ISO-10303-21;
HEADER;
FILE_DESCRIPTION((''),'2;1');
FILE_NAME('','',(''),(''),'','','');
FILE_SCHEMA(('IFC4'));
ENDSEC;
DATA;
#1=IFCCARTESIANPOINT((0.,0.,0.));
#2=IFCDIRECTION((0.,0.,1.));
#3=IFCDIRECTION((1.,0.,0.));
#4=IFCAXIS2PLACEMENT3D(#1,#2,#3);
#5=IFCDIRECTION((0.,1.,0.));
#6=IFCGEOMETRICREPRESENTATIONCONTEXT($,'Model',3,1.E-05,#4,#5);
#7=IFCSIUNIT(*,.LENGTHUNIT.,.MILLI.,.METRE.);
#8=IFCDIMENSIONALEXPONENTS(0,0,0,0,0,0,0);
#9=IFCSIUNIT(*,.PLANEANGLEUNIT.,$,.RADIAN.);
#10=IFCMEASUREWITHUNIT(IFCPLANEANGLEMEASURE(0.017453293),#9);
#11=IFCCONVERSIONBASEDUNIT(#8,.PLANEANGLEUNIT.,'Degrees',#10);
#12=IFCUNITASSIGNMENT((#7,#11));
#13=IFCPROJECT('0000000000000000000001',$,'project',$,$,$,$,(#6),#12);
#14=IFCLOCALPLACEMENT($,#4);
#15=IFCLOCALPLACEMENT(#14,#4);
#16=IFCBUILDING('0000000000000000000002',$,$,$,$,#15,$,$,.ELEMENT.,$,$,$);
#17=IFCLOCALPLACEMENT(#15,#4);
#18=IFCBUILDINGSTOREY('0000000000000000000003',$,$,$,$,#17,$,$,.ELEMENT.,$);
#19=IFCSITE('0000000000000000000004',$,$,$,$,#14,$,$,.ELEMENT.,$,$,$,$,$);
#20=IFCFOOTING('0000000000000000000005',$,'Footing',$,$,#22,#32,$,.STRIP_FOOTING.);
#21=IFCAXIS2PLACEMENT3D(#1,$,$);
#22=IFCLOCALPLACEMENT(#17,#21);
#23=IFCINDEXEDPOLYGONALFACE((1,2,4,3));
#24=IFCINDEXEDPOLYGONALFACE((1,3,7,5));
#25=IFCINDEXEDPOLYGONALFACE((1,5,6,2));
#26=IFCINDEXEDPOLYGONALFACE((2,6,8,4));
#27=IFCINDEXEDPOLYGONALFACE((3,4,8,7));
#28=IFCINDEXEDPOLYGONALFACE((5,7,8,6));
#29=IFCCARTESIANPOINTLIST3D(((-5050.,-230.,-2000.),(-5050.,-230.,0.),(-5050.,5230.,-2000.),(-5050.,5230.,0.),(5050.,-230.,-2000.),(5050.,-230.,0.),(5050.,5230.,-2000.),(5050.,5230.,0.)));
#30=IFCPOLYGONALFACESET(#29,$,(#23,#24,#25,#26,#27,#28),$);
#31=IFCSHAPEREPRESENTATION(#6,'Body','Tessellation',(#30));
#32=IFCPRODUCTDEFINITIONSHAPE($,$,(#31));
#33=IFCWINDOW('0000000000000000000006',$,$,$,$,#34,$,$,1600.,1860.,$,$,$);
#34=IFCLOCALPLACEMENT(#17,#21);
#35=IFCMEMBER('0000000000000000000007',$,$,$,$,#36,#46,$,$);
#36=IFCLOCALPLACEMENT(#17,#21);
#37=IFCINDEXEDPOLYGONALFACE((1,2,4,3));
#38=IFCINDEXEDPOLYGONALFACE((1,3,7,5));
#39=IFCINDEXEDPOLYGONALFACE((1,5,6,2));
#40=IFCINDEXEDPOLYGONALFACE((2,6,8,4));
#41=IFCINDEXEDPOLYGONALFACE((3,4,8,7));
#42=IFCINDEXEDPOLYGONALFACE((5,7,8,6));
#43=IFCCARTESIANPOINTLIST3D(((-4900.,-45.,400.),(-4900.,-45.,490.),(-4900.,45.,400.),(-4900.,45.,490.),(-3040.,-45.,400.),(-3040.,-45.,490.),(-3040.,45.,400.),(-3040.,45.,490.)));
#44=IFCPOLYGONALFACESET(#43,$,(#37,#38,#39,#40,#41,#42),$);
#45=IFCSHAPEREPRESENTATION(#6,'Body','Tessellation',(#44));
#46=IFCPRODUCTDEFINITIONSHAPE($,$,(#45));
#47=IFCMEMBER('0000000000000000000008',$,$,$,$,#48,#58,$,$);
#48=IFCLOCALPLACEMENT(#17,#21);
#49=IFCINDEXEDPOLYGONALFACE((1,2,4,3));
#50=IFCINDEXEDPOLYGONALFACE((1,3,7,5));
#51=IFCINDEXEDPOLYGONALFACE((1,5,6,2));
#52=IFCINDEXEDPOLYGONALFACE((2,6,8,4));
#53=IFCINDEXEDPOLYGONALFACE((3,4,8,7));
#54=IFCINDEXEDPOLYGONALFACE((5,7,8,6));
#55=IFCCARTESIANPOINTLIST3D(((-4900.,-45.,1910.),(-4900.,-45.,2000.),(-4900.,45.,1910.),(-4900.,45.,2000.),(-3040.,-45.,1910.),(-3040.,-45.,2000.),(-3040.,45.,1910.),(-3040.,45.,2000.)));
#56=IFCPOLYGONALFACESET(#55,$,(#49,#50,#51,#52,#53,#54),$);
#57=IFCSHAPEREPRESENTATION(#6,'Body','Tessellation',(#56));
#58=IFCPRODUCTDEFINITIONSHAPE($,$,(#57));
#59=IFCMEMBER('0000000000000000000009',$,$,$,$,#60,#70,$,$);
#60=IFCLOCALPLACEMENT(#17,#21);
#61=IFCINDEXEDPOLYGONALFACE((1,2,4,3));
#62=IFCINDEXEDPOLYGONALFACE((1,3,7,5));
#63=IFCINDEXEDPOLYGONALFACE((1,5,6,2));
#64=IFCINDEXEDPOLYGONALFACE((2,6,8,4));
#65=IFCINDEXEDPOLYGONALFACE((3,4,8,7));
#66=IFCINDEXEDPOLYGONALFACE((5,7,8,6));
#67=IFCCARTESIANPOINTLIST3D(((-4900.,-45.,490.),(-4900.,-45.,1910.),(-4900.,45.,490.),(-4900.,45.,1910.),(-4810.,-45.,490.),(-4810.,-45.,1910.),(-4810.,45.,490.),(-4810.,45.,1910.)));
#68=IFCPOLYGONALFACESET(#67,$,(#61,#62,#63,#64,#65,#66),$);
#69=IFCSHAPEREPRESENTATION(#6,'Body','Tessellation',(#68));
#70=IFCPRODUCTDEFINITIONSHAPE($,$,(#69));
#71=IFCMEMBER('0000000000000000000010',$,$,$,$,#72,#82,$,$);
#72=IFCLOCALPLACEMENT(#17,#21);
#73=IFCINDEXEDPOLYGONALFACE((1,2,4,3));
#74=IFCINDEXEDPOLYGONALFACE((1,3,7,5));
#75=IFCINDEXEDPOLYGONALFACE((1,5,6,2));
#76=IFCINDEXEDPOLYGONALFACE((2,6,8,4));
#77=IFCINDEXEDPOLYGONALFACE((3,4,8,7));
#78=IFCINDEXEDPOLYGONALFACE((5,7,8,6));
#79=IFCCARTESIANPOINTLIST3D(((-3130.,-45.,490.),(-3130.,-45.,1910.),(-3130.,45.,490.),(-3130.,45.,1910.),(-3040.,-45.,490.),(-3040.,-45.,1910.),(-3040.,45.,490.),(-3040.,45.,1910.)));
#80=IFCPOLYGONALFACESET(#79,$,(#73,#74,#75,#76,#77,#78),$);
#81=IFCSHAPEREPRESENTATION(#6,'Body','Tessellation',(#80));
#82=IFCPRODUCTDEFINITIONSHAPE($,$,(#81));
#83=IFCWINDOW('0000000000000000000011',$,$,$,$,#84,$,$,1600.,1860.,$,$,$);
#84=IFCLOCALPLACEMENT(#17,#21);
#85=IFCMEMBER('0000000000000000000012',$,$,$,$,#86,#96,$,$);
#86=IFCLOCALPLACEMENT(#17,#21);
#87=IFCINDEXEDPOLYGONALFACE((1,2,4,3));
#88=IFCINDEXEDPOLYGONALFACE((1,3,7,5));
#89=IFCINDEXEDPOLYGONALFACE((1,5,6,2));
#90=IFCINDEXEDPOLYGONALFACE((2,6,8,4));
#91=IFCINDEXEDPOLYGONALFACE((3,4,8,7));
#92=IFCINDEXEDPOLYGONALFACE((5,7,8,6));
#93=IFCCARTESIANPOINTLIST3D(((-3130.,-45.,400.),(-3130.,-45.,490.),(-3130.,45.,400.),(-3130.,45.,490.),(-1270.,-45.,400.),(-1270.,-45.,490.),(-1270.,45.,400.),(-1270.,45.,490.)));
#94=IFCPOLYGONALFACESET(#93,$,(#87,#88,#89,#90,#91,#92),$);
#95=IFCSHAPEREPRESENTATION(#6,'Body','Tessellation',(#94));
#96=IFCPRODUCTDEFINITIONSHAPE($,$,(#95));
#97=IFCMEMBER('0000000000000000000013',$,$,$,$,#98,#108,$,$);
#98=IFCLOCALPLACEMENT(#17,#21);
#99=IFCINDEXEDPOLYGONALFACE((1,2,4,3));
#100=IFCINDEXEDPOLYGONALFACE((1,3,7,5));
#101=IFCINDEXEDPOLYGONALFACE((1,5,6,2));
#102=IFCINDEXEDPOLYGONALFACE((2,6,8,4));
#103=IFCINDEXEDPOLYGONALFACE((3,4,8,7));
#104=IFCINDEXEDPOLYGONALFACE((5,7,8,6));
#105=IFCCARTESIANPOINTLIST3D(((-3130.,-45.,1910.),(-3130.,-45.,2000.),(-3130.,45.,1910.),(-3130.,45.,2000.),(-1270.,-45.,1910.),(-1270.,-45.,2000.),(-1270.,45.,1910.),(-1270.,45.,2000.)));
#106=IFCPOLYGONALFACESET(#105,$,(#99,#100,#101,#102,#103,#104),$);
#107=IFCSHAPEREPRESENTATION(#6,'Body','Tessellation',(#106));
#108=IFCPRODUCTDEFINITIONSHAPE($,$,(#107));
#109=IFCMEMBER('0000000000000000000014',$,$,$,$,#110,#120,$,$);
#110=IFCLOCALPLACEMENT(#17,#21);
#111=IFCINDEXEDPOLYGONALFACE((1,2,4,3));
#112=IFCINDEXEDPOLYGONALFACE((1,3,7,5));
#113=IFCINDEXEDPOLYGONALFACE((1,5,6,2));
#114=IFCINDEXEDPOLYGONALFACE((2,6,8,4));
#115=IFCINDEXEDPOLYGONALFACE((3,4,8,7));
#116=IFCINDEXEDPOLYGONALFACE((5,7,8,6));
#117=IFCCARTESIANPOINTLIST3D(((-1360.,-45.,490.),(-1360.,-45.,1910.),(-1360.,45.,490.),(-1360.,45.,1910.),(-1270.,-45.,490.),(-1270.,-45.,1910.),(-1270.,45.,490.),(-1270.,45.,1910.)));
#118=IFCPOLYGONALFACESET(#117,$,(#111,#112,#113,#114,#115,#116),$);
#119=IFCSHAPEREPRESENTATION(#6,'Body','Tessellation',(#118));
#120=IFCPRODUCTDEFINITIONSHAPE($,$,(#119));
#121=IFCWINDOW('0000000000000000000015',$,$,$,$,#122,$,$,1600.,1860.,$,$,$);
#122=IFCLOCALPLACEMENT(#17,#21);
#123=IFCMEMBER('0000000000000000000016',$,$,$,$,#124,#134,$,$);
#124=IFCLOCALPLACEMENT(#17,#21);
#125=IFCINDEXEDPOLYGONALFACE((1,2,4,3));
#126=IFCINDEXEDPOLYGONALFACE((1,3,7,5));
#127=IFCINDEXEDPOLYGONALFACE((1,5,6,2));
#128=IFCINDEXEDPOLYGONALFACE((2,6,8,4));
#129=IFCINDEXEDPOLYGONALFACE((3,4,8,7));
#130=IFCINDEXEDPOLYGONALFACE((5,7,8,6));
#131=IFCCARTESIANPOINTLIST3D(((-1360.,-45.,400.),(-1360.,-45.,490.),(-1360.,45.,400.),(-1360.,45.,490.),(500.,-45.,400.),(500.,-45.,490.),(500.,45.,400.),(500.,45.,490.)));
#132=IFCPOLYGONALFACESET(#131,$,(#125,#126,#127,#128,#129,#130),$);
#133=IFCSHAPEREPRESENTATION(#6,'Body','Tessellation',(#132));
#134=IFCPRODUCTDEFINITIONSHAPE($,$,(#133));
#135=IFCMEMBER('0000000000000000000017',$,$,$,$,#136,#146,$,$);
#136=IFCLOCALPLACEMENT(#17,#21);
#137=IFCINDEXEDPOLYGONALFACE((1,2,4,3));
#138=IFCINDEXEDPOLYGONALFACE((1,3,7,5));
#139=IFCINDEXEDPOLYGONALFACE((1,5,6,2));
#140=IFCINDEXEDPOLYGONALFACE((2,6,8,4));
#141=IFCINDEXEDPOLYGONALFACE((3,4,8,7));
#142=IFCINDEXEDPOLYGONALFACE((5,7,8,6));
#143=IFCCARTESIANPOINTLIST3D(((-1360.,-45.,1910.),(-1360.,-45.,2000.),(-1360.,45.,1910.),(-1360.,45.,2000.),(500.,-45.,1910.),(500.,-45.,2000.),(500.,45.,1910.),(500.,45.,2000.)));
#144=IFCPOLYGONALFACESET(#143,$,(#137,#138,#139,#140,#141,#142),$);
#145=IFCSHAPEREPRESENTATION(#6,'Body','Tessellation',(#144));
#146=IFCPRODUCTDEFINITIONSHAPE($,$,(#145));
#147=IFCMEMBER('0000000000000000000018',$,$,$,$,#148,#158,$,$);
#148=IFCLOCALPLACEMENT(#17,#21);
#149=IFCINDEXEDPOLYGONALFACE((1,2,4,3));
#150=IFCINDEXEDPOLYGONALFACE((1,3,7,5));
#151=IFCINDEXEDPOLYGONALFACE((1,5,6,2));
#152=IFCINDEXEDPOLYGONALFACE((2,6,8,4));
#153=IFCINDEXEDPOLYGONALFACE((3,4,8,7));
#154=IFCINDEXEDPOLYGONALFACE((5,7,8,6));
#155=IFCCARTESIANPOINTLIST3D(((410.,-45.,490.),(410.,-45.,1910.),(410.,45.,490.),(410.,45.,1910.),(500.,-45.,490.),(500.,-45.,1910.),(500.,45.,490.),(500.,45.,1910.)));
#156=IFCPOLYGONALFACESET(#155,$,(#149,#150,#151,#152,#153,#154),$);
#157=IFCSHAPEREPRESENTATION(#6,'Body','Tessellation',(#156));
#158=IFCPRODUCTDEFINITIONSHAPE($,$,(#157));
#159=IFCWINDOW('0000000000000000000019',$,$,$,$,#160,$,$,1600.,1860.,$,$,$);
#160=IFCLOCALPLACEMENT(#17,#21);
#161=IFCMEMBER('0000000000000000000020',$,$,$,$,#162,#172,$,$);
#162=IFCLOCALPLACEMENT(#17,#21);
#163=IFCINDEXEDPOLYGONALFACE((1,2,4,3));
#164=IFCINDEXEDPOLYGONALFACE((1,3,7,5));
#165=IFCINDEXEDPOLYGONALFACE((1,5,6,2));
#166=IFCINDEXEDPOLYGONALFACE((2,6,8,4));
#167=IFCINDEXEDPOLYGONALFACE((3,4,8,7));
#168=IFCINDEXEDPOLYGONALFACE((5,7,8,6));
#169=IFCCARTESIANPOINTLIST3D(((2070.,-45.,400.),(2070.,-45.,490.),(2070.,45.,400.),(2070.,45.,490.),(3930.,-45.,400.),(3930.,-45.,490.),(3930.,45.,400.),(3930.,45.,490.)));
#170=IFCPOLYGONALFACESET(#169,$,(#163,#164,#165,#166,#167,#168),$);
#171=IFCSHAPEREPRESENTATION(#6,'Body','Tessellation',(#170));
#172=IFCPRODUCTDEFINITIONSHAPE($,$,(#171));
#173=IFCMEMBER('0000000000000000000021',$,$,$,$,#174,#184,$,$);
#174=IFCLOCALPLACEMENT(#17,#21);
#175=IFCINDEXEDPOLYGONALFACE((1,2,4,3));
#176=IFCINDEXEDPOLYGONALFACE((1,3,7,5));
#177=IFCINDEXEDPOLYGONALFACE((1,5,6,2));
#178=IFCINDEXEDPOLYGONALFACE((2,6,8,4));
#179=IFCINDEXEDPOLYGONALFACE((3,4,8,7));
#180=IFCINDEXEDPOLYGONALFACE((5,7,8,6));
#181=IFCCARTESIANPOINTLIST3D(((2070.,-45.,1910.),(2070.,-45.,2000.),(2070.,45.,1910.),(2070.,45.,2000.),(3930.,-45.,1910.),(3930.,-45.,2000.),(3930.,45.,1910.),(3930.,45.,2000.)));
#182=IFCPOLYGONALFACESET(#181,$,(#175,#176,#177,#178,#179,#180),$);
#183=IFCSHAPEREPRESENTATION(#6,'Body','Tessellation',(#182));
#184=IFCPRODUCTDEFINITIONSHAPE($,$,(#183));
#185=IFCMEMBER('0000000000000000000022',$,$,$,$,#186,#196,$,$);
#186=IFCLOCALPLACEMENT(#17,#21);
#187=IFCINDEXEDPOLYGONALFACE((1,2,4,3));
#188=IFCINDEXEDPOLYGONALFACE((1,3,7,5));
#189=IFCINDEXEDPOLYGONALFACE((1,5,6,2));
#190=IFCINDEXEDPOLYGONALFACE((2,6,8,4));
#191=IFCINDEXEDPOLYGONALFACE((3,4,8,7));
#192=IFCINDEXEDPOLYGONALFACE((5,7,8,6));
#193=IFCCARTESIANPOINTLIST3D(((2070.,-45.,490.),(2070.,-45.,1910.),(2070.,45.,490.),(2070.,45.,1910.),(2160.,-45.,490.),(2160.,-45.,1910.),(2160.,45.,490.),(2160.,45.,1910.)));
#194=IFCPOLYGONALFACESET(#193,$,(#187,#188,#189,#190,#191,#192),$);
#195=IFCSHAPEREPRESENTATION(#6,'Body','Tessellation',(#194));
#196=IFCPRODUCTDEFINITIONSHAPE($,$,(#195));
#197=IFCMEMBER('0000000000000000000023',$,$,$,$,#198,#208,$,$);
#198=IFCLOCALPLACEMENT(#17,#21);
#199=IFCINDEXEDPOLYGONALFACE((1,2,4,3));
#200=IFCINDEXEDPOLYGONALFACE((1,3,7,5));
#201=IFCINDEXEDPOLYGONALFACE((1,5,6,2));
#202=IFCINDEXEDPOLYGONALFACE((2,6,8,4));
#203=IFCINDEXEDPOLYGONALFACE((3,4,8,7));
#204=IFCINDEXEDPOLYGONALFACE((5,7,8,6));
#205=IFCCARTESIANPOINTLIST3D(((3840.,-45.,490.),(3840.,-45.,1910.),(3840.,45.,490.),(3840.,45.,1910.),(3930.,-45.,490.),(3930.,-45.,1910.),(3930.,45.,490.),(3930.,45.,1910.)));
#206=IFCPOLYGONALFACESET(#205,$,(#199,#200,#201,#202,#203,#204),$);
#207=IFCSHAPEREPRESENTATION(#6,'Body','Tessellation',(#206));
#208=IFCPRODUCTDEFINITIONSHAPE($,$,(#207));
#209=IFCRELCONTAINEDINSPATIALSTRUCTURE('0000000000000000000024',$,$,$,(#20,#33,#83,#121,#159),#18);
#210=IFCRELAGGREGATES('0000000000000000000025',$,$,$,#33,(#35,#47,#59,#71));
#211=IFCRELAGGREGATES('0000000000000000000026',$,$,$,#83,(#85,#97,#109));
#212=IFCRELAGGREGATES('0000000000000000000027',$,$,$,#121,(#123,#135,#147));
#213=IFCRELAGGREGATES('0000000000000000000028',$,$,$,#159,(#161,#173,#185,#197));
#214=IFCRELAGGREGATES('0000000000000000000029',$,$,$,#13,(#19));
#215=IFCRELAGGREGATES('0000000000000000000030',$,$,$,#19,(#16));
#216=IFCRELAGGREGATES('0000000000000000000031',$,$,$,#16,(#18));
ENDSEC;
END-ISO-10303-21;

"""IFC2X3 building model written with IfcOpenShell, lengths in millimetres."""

from ifc_helpers import new_model, entity, si_unit, converted_unit, direction, frame, origin_with_axes, place, context, project, spatial, polyline, outline, extrude, element, aggregate, save


model = new_model("IFC2X3")

# Units and contexts
model_context = context("Model", 3, precision=1e-05, world=origin_with_axes(), true_north=direction((0.0, 1.0, 0.0)))
ifc_project = project(units=[si_unit("LENGTHUNIT", "METRE", prefix="MILLI"), converted_unit("PLANEANGLEUNIT", "Degrees", entity("IfcPlaneAngleMeasure", 0.017453293), si_unit("PLANEANGLEUNIT", "RADIAN"), dimensions=[0, 0, 0, 0, 0, 0, 0])], contexts=[model_context])

# Site, building, storey
site_placement = place(None, origin_with_axes())
site = spatial("IfcSite", under=ifc_project, at=site_placement, CompositionType="ELEMENT")
building_placement = place(site_placement, origin_with_axes())
building = spatial("IfcBuilding", under=site, at=building_placement, CompositionType="ELEMENT")
storey_placement = place(building_placement, origin_with_axes())
storey = spatial("IfcBuildingStorey", under=building, at=storey_placement, CompositionType="ELEMENT")

# Footing
footing_placement = place(None, frame((0.0, 2500.0, -2000.0), z_axis=(0.0, 0.0, 1.0), x_axis=(1.0, 0.0, 0.0)))
element("IfcFooting", 1, at=footing_placement, inside=storey, Name="Footing", PredefinedType="STRIP_FOOTING", context=model_context, shape_type="SweptSolid", body=[
    extrude(outline(polyline([(-5050.0, -2730.0), (5050.0, -2730.0), (5050.0, 2730.0), (-5050.0, 2730.0), (-5050.0, -2730.0)])), origin_with_axes(), (0.0, 0.0, 1.0), 2000.0),
])

# Windows, members
window_1_placement = place(storey_placement, frame((-4900.0, -45.0, 400.0), z_axis=(0.0, 0.0, 1.0), x_axis=(1.0, 0.0, 0.0)))
window_1 = element("IfcWindow", 2, at=window_1_placement, inside=storey, OverallHeight=1600.0, OverallWidth=1860.0)
member_1_placement = place(window_1_placement, frame((930.0, 45.0, 0.0), z_axis=(0.0, 0.0, 1.0), x_axis=(1.0, 0.0, 0.0)))
member_1 = element("IfcMember", 3, at=member_1_placement, context=model_context, shape_type="SweptSolid", body=[
    extrude(outline(polyline([(-930.0, -45.0), (930.0, -45.0), (930.0, 45.0), (-930.0, 45.0), (-930.0, -45.0)])), origin_with_axes(), (0.0, 0.0, 1.0), 90.0),
])
member_2_placement = place(window_1_placement, frame((930.0, 45.0, 1510.0), z_axis=(0.0, 0.0, 1.0), x_axis=(1.0, 0.0, 0.0)))
member_2 = element("IfcMember", 4, at=member_2_placement, context=model_context, shape_type="SweptSolid", body=[
    extrude(outline(polyline([(-930.0, -45.0), (930.0, -45.0), (930.0, 45.0), (-930.0, 45.0), (-930.0, -45.0)])), origin_with_axes(), (0.0, 0.0, 1.0), 90.0),
])
member_3_placement = place(window_1_placement, frame((45.0, 45.0, 90.0), z_axis=(0.0, 0.0, 1.0), x_axis=(1.0, 0.0, 0.0)))
member_3 = element("IfcMember", 5, at=member_3_placement, context=model_context, shape_type="SweptSolid", body=[
    extrude(outline(polyline([(-45.0, -45.0), (45.0, -45.0), (45.0, 45.0), (-45.0, 45.0), (-45.0, -45.0)])), origin_with_axes(), (0.0, 0.0, 1.0), 1420.0),
])
member_4_placement = place(window_1_placement, frame((1815.0, 45.0, 90.0), z_axis=(0.0, 0.0, 1.0), x_axis=(1.0, 0.0, 0.0)))
member_4 = element("IfcMember", 6, at=member_4_placement, context=model_context, shape_type="SweptSolid", body=[
    extrude(outline(polyline([(-45.0, -45.0), (45.0, -45.0), (45.0, 45.0), (-45.0, 45.0), (-45.0, -45.0)])), origin_with_axes(), (0.0, 0.0, 1.0), 1420.0),
])
window_2_placement = place(storey_placement, frame((-3130.0, -45.0, 400.0), z_axis=(0.0, 0.0, 1.0), x_axis=(1.0, 0.0, 0.0)))
window_2 = element("IfcWindow", 7, at=window_2_placement, inside=storey, OverallHeight=1600.0, OverallWidth=1860.0)
member_5_placement = place(window_2_placement, frame((930.0, 45.0, 0.0), z_axis=(0.0, 0.0, 1.0), x_axis=(1.0, 0.0, 0.0)))
member_5 = element("IfcMember", 8, at=member_5_placement, context=model_context, shape_type="SweptSolid", body=[
    extrude(outline(polyline([(-930.0, -45.0), (930.0, -45.0), (930.0, 45.0), (-930.0, 45.0), (-930.0, -45.0)])), origin_with_axes(), (0.0, 0.0, 1.0), 90.0),
])
member_6_placement = place(window_2_placement, frame((930.0, 45.0, 1510.0), z_axis=(0.0, 0.0, 1.0), x_axis=(1.0, 0.0, 0.0)))
member_6 = element("IfcMember", 9, at=member_6_placement, context=model_context, shape_type="SweptSolid", body=[
    extrude(outline(polyline([(-930.0, -45.0), (930.0, -45.0), (930.0, 45.0), (-930.0, 45.0), (-930.0, -45.0)])), origin_with_axes(), (0.0, 0.0, 1.0), 90.0),
])
member_7_placement = place(window_2_placement, frame((1815.0, 45.0, 90.0), z_axis=(0.0, 0.0, 1.0), x_axis=(1.0, 0.0, 0.0)))
member_7 = element("IfcMember", 10, at=member_7_placement, context=model_context, shape_type="SweptSolid", body=[
    extrude(outline(polyline([(-45.0, -45.0), (45.0, -45.0), (45.0, 45.0), (-45.0, 45.0), (-45.0, -45.0)])), origin_with_axes(), (0.0, 0.0, 1.0), 1420.0),
])
window_3_placement = place(storey_placement, frame((-1360.0, -45.0, 400.0), z_axis=(0.0, 0.0, 1.0), x_axis=(1.0, 0.0, 0.0)))
window_3 = element("IfcWindow", 11, at=window_3_placement, inside=storey, OverallHeight=1600.0, OverallWidth=1860.0)
member_8_placement = place(window_3_placement, frame((930.0, 45.0, 0.0), z_axis=(0.0, 0.0, 1.0), x_axis=(1.0, 0.0, 0.0)))
member_8 = element("IfcMember", 12, at=member_8_placement, context=model_context, shape_type="SweptSolid", body=[
    extrude(outline(polyline([(-930.0, -45.0), (930.0, -45.0), (930.0, 45.0), (-930.0, 45.0), (-930.0, -45.0)])), origin_with_axes(), (0.0, 0.0, 1.0), 90.0),
])
member_9_placement = place(window_3_placement, frame((930.0, 45.0, 1510.0), z_axis=(0.0, 0.0, 1.0), x_axis=(1.0, 0.0, 0.0)))
member_9 = element("IfcMember", 13, at=member_9_placement, context=model_context, shape_type="SweptSolid", body=[
    extrude(outline(polyline([(-930.0, -45.0), (930.0, -45.0), (930.0, 45.0), (-930.0, 45.0), (-930.0, -45.0)])), origin_with_axes(), (0.0, 0.0, 1.0), 90.0),
])
member_10_placement = place(window_3_placement, frame((1815.0, 45.0, 90.0), z_axis=(0.0, 0.0, 1.0), x_axis=(1.0, 0.0, 0.0)))
member_10 = element("IfcMember", 14, at=member_10_placement, context=model_context, shape_type="SweptSolid", body=[
    extrude(outline(polyline([(-45.0, -45.0), (45.0, -45.0), (45.0, 45.0), (-45.0, 45.0), (-45.0, -45.0)])), origin_with_axes(), (0.0, 0.0, 1.0), 1420.0),
])
window_4_placement = place(storey_placement, frame((2070.0, -45.0, 400.0), z_axis=(0.0, 0.0, 1.0), x_axis=(1.0, 0.0, 0.0)))
window_4 = element("IfcWindow", 15, at=window_4_placement, inside=storey, OverallHeight=1600.0, OverallWidth=1860.0)
member_11_placement = place(window_4_placement, frame((930.0, 45.0, 0.0), z_axis=(0.0, 0.0, 1.0), x_axis=(1.0, 0.0, 0.0)))
member_11 = element("IfcMember", 16, at=member_11_placement, context=model_context, shape_type="SweptSolid", body=[
    extrude(outline(polyline([(-930.0, -45.0), (930.0, -45.0), (930.0, 45.0), (-930.0, 45.0), (-930.0, -45.0)])), origin_with_axes(), (0.0, 0.0, 1.0), 90.0),
])
member_12_placement = place(window_4_placement, frame((930.0, 45.0, 1510.0), z_axis=(0.0, 0.0, 1.0), x_axis=(1.0, 0.0, 0.0)))
member_12 = element("IfcMember", 17, at=member_12_placement, context=model_context, shape_type="SweptSolid", body=[
    extrude(outline(polyline([(-930.0, -45.0), (930.0, -45.0), (930.0, 45.0), (-930.0, 45.0), (-930.0, -45.0)])), origin_with_axes(), (0.0, 0.0, 1.0), 90.0),
])
member_13_placement = place(window_4_placement, frame((45.0, 45.0, 90.0), z_axis=(0.0, 0.0, 1.0), x_axis=(1.0, 0.0, 0.0)))
member_13 = element("IfcMember", 18, at=member_13_placement, context=model_context, shape_type="SweptSolid", body=[
    extrude(outline(polyline([(-45.0, -45.0), (45.0, -45.0), (45.0, 45.0), (-45.0, 45.0), (-45.0, -45.0)])), origin_with_axes(), (0.0, 0.0, 1.0), 1420.0),
])
member_14_placement = place(window_4_placement, frame((1815.0, 45.0, 90.0), z_axis=(0.0, 0.0, 1.0), x_axis=(1.0, 0.0, 0.0)))
member_14 = element("IfcMember", 19, at=member_14_placement, context=model_context, shape_type="SweptSolid", body=[
    extrude(outline(polyline([(-45.0, -45.0), (45.0, -45.0), (45.0, 45.0), (-45.0, 45.0), (-45.0, -45.0)])), origin_with_axes(), (0.0, 0.0, 1.0), 1420.0),
])

aggregate(window_1, [member_1, member_2, member_3, member_4])
aggregate(window_2, [member_5, member_6, member_7])
aggregate(window_3, [member_8, member_9, member_10])
aggregate(window_4, [member_11, member_12, member_13, member_14])

save(model, "model.ifc")
